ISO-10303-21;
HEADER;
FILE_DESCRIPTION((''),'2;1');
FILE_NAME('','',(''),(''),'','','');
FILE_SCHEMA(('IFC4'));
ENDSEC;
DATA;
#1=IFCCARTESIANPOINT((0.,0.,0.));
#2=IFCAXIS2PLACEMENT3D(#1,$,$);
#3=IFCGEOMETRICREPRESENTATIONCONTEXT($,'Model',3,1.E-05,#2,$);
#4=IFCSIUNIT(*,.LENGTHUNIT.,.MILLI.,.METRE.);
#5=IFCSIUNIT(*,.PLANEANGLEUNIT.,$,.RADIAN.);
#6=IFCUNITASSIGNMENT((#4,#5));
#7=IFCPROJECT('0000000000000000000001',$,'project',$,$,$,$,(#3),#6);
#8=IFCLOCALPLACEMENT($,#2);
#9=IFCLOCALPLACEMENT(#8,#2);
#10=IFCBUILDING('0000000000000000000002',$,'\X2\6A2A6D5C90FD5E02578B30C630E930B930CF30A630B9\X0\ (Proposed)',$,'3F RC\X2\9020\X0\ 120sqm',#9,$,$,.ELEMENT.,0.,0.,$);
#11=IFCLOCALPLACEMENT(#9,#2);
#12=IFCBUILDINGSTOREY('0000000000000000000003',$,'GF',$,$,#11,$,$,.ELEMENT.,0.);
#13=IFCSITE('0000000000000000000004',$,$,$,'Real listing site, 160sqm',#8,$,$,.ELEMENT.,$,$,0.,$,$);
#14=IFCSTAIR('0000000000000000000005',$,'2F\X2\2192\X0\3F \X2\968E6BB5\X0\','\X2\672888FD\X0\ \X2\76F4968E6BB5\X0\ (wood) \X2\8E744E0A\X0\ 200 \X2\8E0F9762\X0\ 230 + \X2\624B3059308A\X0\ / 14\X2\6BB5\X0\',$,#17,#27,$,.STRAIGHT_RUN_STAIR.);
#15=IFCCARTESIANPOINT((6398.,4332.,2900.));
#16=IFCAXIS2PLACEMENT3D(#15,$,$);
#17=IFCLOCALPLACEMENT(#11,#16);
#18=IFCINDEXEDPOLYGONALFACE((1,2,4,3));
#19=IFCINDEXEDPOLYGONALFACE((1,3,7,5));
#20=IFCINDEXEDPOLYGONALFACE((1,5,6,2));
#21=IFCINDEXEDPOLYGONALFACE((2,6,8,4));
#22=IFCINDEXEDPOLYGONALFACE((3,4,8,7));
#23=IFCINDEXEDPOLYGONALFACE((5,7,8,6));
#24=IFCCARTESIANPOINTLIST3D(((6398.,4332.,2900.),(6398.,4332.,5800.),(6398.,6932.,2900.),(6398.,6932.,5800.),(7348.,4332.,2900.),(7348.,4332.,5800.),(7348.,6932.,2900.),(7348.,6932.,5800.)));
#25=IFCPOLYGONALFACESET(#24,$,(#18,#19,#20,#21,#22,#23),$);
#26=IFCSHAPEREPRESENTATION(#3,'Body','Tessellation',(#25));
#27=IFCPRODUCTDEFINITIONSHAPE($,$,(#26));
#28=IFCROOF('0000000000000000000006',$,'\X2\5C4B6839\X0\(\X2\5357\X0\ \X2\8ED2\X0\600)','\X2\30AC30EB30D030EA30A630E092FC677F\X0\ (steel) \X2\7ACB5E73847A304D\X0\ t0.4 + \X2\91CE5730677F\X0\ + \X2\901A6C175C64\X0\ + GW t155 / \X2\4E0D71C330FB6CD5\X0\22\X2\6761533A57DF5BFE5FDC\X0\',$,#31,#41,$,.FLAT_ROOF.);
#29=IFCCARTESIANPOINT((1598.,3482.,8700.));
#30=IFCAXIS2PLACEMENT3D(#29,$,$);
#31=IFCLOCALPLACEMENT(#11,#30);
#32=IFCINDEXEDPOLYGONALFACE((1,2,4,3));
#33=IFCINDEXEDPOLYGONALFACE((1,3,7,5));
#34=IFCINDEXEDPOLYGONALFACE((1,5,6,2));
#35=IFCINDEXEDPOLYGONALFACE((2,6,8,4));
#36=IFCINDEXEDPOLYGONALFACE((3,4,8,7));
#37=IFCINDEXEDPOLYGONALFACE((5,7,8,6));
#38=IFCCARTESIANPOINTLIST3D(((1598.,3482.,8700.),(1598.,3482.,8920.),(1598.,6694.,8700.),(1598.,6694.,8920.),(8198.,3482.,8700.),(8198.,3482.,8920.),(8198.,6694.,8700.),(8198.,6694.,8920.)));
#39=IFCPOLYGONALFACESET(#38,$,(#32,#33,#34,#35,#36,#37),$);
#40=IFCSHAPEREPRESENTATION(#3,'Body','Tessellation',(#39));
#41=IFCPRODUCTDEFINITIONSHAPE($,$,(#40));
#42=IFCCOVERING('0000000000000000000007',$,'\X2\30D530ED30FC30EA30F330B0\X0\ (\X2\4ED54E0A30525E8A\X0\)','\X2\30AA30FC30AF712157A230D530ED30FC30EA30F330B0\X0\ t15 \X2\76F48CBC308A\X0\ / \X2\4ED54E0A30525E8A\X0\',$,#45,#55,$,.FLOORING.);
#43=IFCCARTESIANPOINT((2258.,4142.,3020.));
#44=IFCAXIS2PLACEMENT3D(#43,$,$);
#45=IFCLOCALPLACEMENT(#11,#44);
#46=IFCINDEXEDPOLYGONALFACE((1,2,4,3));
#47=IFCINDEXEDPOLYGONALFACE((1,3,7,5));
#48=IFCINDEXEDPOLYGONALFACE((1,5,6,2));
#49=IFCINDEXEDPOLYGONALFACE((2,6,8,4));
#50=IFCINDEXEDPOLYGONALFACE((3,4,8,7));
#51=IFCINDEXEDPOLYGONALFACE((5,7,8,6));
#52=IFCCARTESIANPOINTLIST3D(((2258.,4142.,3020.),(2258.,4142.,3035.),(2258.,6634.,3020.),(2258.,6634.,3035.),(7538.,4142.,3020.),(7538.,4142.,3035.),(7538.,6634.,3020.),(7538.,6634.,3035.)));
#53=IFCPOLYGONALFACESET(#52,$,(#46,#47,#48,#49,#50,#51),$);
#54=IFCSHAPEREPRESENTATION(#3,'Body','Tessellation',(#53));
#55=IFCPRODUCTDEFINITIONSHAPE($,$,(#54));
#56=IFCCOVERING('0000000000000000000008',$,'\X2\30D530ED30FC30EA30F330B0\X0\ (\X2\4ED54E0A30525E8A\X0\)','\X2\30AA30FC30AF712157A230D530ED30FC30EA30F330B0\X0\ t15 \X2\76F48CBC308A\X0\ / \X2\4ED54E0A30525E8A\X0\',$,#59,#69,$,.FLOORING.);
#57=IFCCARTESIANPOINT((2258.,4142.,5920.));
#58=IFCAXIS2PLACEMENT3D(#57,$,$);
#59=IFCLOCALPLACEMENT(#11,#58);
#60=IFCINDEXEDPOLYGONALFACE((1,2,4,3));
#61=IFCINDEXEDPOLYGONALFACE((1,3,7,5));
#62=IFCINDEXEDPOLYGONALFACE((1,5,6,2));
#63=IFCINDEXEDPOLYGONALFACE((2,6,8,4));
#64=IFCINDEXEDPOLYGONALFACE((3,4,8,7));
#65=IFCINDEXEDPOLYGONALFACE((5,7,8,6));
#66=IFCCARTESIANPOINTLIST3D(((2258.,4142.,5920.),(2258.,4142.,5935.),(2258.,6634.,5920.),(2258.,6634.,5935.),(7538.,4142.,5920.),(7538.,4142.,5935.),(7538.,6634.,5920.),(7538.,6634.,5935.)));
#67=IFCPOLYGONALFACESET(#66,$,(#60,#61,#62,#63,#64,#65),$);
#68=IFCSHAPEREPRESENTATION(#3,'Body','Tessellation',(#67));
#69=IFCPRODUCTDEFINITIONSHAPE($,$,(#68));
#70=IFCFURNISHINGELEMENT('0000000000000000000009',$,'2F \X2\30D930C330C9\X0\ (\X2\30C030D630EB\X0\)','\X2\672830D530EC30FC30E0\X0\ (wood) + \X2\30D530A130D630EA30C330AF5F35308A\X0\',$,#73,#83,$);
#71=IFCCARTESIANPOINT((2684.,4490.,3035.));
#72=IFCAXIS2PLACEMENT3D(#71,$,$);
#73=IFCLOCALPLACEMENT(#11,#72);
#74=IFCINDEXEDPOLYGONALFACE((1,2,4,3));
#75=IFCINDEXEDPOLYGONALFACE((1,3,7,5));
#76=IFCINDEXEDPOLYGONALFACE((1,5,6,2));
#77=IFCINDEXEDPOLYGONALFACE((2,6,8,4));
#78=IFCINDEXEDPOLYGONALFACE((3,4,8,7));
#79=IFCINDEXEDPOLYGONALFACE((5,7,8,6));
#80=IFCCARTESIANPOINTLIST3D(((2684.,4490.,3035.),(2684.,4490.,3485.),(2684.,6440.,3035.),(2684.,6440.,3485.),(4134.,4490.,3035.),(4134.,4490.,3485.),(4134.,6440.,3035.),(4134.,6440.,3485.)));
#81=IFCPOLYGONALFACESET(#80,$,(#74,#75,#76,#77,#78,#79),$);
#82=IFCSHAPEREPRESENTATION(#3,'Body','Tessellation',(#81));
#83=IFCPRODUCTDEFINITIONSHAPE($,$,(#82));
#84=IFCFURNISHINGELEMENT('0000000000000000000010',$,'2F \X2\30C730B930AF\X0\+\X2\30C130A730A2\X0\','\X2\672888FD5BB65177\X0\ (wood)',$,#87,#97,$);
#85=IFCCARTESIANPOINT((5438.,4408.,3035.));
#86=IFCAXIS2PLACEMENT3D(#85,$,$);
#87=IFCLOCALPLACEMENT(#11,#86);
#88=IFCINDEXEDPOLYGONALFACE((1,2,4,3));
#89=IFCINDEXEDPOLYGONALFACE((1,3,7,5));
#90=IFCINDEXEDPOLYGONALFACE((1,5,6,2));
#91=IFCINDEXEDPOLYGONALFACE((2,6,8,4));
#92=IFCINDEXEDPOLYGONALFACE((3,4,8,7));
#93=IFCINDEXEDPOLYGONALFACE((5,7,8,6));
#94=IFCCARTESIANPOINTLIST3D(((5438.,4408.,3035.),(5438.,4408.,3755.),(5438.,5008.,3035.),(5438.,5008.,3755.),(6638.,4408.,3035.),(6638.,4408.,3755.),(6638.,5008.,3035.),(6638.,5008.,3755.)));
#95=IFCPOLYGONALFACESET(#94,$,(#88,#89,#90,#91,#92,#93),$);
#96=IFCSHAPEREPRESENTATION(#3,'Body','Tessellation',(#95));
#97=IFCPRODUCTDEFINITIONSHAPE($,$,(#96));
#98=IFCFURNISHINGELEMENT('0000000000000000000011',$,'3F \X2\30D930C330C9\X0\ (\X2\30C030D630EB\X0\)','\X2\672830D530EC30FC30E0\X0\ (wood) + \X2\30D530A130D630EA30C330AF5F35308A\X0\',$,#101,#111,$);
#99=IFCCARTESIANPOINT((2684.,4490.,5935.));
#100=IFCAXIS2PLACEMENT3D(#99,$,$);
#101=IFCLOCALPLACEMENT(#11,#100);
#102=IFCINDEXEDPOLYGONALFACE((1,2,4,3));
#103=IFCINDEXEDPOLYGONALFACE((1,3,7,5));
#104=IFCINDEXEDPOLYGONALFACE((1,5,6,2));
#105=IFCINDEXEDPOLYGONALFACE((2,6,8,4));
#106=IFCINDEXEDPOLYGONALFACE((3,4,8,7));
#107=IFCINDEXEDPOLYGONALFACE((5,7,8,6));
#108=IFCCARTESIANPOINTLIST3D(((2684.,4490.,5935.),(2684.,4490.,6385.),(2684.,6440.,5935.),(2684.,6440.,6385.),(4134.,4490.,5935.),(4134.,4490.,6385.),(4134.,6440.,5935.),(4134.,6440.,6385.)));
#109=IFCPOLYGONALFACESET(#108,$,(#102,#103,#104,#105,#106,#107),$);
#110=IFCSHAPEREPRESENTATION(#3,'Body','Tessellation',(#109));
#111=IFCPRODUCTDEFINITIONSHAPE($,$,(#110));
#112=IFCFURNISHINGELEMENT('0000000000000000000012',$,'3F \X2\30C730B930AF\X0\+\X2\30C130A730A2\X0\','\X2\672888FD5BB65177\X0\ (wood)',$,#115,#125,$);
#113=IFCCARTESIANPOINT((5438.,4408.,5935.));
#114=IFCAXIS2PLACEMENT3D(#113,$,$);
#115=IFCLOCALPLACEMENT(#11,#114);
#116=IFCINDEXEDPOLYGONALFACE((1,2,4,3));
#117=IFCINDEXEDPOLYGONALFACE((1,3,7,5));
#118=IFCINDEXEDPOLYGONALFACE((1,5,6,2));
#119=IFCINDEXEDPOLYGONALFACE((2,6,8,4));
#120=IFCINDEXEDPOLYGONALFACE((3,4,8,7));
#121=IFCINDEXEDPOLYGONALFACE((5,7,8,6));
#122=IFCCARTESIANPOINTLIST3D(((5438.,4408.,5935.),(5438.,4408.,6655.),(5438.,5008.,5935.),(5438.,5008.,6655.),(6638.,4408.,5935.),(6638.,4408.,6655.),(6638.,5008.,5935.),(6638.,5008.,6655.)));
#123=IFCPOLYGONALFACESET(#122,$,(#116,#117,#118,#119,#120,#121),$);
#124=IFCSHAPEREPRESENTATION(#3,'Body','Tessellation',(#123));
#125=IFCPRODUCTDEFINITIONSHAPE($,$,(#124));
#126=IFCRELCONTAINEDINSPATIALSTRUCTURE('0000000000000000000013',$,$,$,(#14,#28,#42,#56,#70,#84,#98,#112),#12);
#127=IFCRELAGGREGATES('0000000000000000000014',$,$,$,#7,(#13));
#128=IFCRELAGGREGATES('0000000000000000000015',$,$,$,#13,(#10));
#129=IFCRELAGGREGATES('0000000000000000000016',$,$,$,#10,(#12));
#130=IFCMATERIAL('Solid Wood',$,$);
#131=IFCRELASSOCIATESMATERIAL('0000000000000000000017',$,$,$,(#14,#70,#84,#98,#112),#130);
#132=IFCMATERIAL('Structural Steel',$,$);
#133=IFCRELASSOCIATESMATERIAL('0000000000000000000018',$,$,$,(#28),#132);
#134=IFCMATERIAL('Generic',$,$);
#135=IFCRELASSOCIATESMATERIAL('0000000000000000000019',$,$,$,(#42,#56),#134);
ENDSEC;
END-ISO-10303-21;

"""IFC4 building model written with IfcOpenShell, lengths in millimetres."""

from ifc_helpers import new_model, si_unit, frame, frame_2d, origin, place, context, project, spatial, rectangle, extrude, material, element, save


model = new_model("IFC4")

# Units and contexts
model_context = context("Model", 3, precision=1e-05, world=origin())
ifc_project = project(units=[si_unit("LENGTHUNIT", "METRE", prefix="MILLI"), si_unit("PLANEANGLEUNIT", "RADIAN")], contexts=[model_context])

# Site, building, storey
site_placement = place(None, origin())
site = spatial("IfcSite", under=ifc_project, at=site_placement, ObjectType="Real listing site, 160sqm", CompositionType="ELEMENT", RefElevation=0.0)
building_placement = place(site_placement, origin())
building = spatial("IfcBuilding", under=site, at=building_placement, Name="横浜都市型テラスハウス (Proposed)", ObjectType="3F RC造 120sqm", CompositionType="ELEMENT", ElevationOfRefHeight=0.0, ElevationOfTerrain=0.0)
storey_placement = place(building_placement, origin())
storey = spatial("IfcBuildingStorey", under=building, at=storey_placement, Name="GF", CompositionType="ELEMENT", Elevation=0.0)

# Shared definitions
ifc_material_1 = material(Name="Solid Wood")

# Stair
stair_placement = place(storey_placement, frame((6398.0, 4332.0, 2900.0)))
element("IfcStair", 1, at=stair_placement, inside=storey, material=ifc_material_1, Name="2F→3F 階段", Description="木製 直階段 (wood) 蹴上 200 踏面 230 + 手すり / 14段", PredefinedType="STRAIGHT_RUN_STAIR", context=model_context, shape_type="SweptSolid", body=[
    extrude(rectangle(XDim=950.0, YDim=2600.0, at=frame_2d((475.0, 1300.0))), frame((6398.0, 4332.0, 2900.0)), (0.0, 0.0, 1.0), 2900.0),
])

# Roof
ifc_material_2 = material(Name="Structural Steel")
for number, where, name in (
    (2, (1598.0, 3482.0, 8700.0), "屋根(南 軒600)"),
):
    element("IfcRoof", number, at=place(storey_placement, frame(where)), inside=storey, material=ifc_material_2, Name=name, Description="ガルバリウム鋼板 (steel) 立平葺き t0.4 + 野地板 + 通気層 + GW t155 / 不燃・法22条区域対応", PredefinedType="FLAT_ROOF", context=model_context, shape_type="SweptSolid", body=[
        extrude(rectangle(XDim=6600.0, YDim=3212.0, at=frame_2d((3300.0, 1606.0))), frame((1598.0, 3482.0, 8700.0)), (0.0, 0.0, 1.0), 220.0),
    ])

# Coverings
ifc_material_3 = material(Name="Generic")
covering_1_placement = place(storey_placement, frame((2258.0, 4142.0, 3020.0)))
element("IfcCovering", 3, at=covering_1_placement, inside=storey, material=ifc_material_3, Name="フローリング (仕上げ床)", Description="オーク無垢フローリング t15 直貼り / 仕上げ床", PredefinedType="FLOORING", context=model_context, shape_type="SweptSolid", body=[
    extrude(rectangle(XDim=5280.0, YDim=2492.0, at=frame_2d((2640.0, 1246.0))), frame((2258.0, 4142.0, 3020.0)), (0.0, 0.0, 1.0), 15.0),
])
covering_2_placement = place(storey_placement, frame((2258.0, 4142.0, 5920.0)))
element("IfcCovering", 4, at=covering_2_placement, inside=storey, material=ifc_material_3, Name="フローリング (仕上げ床)", Description="オーク無垢フローリング t15 直貼り / 仕上げ床", PredefinedType="FLOORING", context=model_context, shape_type="SweptSolid", body=[
    extrude(rectangle(XDim=5280.0, YDim=2492.0, at=frame_2d((2640.0, 1246.0))), frame((2258.0, 4142.0, 5920.0)), (0.0, 0.0, 1.0), 15.0),
])

# Furnishing elements
furnishing_1_placement = place(storey_placement, frame((2684.0, 4490.0, 3035.0)))
element("IfcFurnishingElement", 5, at=furnishing_1_placement, inside=storey, material=ifc_material_1, Name="2F ベッド (ダブル)", Description="木フレーム (wood) + ファブリック張り", context=model_context, shape_type="SweptSolid", body=[
    extrude(rectangle(XDim=1450.0, YDim=1950.0, at=frame_2d((725.0, 975.0))), frame((2684.0, 4490.0, 3035.0)), (0.0, 0.0, 1.0), 450.0),
])
furnishing_2_placement = place(storey_placement, frame((5438.0, 4408.0, 3035.0)))
element("IfcFurnishingElement", 6, at=furnishing_2_placement, inside=storey, material=ifc_material_1, Name="2F デスク+チェア", Description="木製家具 (wood)", context=model_context, shape_type="SweptSolid", body=[
    extrude(rectangle(XDim=1200.0, YDim=600.0, at=frame_2d((600.0, 300.0))), frame((5438.0, 4408.0, 3035.0)), (0.0, 0.0, 1.0), 720.0),
])
furnishing_3_placement = place(storey_placement, frame((2684.0, 4490.0, 5935.0)))
element("IfcFurnishingElement", 7, at=furnishing_3_placement, inside=storey, material=ifc_material_1, Name="3F ベッド (ダブル)", Description="木フレーム (wood) + ファブリック張り", context=model_context, shape_type="SweptSolid", body=[
    extrude(rectangle(XDim=1450.0, YDim=1950.0, at=frame_2d((725.0, 975.0))), frame((2684.0, 4490.0, 5935.0)), (0.0, 0.0, 1.0), 450.0),
])
furnishing_4_placement = place(storey_placement, frame((5438.0, 4408.0, 5935.0)))
element("IfcFurnishingElement", 8, at=furnishing_4_placement, inside=storey, material=ifc_material_1, Name="3F デスク+チェア", Description="木製家具 (wood)", context=model_context, shape_type="SweptSolid", body=[
    extrude(rectangle(XDim=1200.0, YDim=600.0, at=frame_2d((600.0, 300.0))), frame((5438.0, 4408.0, 5935.0)), (0.0, 0.0, 1.0), 720.0),
])

save(model, "model.ifc")
